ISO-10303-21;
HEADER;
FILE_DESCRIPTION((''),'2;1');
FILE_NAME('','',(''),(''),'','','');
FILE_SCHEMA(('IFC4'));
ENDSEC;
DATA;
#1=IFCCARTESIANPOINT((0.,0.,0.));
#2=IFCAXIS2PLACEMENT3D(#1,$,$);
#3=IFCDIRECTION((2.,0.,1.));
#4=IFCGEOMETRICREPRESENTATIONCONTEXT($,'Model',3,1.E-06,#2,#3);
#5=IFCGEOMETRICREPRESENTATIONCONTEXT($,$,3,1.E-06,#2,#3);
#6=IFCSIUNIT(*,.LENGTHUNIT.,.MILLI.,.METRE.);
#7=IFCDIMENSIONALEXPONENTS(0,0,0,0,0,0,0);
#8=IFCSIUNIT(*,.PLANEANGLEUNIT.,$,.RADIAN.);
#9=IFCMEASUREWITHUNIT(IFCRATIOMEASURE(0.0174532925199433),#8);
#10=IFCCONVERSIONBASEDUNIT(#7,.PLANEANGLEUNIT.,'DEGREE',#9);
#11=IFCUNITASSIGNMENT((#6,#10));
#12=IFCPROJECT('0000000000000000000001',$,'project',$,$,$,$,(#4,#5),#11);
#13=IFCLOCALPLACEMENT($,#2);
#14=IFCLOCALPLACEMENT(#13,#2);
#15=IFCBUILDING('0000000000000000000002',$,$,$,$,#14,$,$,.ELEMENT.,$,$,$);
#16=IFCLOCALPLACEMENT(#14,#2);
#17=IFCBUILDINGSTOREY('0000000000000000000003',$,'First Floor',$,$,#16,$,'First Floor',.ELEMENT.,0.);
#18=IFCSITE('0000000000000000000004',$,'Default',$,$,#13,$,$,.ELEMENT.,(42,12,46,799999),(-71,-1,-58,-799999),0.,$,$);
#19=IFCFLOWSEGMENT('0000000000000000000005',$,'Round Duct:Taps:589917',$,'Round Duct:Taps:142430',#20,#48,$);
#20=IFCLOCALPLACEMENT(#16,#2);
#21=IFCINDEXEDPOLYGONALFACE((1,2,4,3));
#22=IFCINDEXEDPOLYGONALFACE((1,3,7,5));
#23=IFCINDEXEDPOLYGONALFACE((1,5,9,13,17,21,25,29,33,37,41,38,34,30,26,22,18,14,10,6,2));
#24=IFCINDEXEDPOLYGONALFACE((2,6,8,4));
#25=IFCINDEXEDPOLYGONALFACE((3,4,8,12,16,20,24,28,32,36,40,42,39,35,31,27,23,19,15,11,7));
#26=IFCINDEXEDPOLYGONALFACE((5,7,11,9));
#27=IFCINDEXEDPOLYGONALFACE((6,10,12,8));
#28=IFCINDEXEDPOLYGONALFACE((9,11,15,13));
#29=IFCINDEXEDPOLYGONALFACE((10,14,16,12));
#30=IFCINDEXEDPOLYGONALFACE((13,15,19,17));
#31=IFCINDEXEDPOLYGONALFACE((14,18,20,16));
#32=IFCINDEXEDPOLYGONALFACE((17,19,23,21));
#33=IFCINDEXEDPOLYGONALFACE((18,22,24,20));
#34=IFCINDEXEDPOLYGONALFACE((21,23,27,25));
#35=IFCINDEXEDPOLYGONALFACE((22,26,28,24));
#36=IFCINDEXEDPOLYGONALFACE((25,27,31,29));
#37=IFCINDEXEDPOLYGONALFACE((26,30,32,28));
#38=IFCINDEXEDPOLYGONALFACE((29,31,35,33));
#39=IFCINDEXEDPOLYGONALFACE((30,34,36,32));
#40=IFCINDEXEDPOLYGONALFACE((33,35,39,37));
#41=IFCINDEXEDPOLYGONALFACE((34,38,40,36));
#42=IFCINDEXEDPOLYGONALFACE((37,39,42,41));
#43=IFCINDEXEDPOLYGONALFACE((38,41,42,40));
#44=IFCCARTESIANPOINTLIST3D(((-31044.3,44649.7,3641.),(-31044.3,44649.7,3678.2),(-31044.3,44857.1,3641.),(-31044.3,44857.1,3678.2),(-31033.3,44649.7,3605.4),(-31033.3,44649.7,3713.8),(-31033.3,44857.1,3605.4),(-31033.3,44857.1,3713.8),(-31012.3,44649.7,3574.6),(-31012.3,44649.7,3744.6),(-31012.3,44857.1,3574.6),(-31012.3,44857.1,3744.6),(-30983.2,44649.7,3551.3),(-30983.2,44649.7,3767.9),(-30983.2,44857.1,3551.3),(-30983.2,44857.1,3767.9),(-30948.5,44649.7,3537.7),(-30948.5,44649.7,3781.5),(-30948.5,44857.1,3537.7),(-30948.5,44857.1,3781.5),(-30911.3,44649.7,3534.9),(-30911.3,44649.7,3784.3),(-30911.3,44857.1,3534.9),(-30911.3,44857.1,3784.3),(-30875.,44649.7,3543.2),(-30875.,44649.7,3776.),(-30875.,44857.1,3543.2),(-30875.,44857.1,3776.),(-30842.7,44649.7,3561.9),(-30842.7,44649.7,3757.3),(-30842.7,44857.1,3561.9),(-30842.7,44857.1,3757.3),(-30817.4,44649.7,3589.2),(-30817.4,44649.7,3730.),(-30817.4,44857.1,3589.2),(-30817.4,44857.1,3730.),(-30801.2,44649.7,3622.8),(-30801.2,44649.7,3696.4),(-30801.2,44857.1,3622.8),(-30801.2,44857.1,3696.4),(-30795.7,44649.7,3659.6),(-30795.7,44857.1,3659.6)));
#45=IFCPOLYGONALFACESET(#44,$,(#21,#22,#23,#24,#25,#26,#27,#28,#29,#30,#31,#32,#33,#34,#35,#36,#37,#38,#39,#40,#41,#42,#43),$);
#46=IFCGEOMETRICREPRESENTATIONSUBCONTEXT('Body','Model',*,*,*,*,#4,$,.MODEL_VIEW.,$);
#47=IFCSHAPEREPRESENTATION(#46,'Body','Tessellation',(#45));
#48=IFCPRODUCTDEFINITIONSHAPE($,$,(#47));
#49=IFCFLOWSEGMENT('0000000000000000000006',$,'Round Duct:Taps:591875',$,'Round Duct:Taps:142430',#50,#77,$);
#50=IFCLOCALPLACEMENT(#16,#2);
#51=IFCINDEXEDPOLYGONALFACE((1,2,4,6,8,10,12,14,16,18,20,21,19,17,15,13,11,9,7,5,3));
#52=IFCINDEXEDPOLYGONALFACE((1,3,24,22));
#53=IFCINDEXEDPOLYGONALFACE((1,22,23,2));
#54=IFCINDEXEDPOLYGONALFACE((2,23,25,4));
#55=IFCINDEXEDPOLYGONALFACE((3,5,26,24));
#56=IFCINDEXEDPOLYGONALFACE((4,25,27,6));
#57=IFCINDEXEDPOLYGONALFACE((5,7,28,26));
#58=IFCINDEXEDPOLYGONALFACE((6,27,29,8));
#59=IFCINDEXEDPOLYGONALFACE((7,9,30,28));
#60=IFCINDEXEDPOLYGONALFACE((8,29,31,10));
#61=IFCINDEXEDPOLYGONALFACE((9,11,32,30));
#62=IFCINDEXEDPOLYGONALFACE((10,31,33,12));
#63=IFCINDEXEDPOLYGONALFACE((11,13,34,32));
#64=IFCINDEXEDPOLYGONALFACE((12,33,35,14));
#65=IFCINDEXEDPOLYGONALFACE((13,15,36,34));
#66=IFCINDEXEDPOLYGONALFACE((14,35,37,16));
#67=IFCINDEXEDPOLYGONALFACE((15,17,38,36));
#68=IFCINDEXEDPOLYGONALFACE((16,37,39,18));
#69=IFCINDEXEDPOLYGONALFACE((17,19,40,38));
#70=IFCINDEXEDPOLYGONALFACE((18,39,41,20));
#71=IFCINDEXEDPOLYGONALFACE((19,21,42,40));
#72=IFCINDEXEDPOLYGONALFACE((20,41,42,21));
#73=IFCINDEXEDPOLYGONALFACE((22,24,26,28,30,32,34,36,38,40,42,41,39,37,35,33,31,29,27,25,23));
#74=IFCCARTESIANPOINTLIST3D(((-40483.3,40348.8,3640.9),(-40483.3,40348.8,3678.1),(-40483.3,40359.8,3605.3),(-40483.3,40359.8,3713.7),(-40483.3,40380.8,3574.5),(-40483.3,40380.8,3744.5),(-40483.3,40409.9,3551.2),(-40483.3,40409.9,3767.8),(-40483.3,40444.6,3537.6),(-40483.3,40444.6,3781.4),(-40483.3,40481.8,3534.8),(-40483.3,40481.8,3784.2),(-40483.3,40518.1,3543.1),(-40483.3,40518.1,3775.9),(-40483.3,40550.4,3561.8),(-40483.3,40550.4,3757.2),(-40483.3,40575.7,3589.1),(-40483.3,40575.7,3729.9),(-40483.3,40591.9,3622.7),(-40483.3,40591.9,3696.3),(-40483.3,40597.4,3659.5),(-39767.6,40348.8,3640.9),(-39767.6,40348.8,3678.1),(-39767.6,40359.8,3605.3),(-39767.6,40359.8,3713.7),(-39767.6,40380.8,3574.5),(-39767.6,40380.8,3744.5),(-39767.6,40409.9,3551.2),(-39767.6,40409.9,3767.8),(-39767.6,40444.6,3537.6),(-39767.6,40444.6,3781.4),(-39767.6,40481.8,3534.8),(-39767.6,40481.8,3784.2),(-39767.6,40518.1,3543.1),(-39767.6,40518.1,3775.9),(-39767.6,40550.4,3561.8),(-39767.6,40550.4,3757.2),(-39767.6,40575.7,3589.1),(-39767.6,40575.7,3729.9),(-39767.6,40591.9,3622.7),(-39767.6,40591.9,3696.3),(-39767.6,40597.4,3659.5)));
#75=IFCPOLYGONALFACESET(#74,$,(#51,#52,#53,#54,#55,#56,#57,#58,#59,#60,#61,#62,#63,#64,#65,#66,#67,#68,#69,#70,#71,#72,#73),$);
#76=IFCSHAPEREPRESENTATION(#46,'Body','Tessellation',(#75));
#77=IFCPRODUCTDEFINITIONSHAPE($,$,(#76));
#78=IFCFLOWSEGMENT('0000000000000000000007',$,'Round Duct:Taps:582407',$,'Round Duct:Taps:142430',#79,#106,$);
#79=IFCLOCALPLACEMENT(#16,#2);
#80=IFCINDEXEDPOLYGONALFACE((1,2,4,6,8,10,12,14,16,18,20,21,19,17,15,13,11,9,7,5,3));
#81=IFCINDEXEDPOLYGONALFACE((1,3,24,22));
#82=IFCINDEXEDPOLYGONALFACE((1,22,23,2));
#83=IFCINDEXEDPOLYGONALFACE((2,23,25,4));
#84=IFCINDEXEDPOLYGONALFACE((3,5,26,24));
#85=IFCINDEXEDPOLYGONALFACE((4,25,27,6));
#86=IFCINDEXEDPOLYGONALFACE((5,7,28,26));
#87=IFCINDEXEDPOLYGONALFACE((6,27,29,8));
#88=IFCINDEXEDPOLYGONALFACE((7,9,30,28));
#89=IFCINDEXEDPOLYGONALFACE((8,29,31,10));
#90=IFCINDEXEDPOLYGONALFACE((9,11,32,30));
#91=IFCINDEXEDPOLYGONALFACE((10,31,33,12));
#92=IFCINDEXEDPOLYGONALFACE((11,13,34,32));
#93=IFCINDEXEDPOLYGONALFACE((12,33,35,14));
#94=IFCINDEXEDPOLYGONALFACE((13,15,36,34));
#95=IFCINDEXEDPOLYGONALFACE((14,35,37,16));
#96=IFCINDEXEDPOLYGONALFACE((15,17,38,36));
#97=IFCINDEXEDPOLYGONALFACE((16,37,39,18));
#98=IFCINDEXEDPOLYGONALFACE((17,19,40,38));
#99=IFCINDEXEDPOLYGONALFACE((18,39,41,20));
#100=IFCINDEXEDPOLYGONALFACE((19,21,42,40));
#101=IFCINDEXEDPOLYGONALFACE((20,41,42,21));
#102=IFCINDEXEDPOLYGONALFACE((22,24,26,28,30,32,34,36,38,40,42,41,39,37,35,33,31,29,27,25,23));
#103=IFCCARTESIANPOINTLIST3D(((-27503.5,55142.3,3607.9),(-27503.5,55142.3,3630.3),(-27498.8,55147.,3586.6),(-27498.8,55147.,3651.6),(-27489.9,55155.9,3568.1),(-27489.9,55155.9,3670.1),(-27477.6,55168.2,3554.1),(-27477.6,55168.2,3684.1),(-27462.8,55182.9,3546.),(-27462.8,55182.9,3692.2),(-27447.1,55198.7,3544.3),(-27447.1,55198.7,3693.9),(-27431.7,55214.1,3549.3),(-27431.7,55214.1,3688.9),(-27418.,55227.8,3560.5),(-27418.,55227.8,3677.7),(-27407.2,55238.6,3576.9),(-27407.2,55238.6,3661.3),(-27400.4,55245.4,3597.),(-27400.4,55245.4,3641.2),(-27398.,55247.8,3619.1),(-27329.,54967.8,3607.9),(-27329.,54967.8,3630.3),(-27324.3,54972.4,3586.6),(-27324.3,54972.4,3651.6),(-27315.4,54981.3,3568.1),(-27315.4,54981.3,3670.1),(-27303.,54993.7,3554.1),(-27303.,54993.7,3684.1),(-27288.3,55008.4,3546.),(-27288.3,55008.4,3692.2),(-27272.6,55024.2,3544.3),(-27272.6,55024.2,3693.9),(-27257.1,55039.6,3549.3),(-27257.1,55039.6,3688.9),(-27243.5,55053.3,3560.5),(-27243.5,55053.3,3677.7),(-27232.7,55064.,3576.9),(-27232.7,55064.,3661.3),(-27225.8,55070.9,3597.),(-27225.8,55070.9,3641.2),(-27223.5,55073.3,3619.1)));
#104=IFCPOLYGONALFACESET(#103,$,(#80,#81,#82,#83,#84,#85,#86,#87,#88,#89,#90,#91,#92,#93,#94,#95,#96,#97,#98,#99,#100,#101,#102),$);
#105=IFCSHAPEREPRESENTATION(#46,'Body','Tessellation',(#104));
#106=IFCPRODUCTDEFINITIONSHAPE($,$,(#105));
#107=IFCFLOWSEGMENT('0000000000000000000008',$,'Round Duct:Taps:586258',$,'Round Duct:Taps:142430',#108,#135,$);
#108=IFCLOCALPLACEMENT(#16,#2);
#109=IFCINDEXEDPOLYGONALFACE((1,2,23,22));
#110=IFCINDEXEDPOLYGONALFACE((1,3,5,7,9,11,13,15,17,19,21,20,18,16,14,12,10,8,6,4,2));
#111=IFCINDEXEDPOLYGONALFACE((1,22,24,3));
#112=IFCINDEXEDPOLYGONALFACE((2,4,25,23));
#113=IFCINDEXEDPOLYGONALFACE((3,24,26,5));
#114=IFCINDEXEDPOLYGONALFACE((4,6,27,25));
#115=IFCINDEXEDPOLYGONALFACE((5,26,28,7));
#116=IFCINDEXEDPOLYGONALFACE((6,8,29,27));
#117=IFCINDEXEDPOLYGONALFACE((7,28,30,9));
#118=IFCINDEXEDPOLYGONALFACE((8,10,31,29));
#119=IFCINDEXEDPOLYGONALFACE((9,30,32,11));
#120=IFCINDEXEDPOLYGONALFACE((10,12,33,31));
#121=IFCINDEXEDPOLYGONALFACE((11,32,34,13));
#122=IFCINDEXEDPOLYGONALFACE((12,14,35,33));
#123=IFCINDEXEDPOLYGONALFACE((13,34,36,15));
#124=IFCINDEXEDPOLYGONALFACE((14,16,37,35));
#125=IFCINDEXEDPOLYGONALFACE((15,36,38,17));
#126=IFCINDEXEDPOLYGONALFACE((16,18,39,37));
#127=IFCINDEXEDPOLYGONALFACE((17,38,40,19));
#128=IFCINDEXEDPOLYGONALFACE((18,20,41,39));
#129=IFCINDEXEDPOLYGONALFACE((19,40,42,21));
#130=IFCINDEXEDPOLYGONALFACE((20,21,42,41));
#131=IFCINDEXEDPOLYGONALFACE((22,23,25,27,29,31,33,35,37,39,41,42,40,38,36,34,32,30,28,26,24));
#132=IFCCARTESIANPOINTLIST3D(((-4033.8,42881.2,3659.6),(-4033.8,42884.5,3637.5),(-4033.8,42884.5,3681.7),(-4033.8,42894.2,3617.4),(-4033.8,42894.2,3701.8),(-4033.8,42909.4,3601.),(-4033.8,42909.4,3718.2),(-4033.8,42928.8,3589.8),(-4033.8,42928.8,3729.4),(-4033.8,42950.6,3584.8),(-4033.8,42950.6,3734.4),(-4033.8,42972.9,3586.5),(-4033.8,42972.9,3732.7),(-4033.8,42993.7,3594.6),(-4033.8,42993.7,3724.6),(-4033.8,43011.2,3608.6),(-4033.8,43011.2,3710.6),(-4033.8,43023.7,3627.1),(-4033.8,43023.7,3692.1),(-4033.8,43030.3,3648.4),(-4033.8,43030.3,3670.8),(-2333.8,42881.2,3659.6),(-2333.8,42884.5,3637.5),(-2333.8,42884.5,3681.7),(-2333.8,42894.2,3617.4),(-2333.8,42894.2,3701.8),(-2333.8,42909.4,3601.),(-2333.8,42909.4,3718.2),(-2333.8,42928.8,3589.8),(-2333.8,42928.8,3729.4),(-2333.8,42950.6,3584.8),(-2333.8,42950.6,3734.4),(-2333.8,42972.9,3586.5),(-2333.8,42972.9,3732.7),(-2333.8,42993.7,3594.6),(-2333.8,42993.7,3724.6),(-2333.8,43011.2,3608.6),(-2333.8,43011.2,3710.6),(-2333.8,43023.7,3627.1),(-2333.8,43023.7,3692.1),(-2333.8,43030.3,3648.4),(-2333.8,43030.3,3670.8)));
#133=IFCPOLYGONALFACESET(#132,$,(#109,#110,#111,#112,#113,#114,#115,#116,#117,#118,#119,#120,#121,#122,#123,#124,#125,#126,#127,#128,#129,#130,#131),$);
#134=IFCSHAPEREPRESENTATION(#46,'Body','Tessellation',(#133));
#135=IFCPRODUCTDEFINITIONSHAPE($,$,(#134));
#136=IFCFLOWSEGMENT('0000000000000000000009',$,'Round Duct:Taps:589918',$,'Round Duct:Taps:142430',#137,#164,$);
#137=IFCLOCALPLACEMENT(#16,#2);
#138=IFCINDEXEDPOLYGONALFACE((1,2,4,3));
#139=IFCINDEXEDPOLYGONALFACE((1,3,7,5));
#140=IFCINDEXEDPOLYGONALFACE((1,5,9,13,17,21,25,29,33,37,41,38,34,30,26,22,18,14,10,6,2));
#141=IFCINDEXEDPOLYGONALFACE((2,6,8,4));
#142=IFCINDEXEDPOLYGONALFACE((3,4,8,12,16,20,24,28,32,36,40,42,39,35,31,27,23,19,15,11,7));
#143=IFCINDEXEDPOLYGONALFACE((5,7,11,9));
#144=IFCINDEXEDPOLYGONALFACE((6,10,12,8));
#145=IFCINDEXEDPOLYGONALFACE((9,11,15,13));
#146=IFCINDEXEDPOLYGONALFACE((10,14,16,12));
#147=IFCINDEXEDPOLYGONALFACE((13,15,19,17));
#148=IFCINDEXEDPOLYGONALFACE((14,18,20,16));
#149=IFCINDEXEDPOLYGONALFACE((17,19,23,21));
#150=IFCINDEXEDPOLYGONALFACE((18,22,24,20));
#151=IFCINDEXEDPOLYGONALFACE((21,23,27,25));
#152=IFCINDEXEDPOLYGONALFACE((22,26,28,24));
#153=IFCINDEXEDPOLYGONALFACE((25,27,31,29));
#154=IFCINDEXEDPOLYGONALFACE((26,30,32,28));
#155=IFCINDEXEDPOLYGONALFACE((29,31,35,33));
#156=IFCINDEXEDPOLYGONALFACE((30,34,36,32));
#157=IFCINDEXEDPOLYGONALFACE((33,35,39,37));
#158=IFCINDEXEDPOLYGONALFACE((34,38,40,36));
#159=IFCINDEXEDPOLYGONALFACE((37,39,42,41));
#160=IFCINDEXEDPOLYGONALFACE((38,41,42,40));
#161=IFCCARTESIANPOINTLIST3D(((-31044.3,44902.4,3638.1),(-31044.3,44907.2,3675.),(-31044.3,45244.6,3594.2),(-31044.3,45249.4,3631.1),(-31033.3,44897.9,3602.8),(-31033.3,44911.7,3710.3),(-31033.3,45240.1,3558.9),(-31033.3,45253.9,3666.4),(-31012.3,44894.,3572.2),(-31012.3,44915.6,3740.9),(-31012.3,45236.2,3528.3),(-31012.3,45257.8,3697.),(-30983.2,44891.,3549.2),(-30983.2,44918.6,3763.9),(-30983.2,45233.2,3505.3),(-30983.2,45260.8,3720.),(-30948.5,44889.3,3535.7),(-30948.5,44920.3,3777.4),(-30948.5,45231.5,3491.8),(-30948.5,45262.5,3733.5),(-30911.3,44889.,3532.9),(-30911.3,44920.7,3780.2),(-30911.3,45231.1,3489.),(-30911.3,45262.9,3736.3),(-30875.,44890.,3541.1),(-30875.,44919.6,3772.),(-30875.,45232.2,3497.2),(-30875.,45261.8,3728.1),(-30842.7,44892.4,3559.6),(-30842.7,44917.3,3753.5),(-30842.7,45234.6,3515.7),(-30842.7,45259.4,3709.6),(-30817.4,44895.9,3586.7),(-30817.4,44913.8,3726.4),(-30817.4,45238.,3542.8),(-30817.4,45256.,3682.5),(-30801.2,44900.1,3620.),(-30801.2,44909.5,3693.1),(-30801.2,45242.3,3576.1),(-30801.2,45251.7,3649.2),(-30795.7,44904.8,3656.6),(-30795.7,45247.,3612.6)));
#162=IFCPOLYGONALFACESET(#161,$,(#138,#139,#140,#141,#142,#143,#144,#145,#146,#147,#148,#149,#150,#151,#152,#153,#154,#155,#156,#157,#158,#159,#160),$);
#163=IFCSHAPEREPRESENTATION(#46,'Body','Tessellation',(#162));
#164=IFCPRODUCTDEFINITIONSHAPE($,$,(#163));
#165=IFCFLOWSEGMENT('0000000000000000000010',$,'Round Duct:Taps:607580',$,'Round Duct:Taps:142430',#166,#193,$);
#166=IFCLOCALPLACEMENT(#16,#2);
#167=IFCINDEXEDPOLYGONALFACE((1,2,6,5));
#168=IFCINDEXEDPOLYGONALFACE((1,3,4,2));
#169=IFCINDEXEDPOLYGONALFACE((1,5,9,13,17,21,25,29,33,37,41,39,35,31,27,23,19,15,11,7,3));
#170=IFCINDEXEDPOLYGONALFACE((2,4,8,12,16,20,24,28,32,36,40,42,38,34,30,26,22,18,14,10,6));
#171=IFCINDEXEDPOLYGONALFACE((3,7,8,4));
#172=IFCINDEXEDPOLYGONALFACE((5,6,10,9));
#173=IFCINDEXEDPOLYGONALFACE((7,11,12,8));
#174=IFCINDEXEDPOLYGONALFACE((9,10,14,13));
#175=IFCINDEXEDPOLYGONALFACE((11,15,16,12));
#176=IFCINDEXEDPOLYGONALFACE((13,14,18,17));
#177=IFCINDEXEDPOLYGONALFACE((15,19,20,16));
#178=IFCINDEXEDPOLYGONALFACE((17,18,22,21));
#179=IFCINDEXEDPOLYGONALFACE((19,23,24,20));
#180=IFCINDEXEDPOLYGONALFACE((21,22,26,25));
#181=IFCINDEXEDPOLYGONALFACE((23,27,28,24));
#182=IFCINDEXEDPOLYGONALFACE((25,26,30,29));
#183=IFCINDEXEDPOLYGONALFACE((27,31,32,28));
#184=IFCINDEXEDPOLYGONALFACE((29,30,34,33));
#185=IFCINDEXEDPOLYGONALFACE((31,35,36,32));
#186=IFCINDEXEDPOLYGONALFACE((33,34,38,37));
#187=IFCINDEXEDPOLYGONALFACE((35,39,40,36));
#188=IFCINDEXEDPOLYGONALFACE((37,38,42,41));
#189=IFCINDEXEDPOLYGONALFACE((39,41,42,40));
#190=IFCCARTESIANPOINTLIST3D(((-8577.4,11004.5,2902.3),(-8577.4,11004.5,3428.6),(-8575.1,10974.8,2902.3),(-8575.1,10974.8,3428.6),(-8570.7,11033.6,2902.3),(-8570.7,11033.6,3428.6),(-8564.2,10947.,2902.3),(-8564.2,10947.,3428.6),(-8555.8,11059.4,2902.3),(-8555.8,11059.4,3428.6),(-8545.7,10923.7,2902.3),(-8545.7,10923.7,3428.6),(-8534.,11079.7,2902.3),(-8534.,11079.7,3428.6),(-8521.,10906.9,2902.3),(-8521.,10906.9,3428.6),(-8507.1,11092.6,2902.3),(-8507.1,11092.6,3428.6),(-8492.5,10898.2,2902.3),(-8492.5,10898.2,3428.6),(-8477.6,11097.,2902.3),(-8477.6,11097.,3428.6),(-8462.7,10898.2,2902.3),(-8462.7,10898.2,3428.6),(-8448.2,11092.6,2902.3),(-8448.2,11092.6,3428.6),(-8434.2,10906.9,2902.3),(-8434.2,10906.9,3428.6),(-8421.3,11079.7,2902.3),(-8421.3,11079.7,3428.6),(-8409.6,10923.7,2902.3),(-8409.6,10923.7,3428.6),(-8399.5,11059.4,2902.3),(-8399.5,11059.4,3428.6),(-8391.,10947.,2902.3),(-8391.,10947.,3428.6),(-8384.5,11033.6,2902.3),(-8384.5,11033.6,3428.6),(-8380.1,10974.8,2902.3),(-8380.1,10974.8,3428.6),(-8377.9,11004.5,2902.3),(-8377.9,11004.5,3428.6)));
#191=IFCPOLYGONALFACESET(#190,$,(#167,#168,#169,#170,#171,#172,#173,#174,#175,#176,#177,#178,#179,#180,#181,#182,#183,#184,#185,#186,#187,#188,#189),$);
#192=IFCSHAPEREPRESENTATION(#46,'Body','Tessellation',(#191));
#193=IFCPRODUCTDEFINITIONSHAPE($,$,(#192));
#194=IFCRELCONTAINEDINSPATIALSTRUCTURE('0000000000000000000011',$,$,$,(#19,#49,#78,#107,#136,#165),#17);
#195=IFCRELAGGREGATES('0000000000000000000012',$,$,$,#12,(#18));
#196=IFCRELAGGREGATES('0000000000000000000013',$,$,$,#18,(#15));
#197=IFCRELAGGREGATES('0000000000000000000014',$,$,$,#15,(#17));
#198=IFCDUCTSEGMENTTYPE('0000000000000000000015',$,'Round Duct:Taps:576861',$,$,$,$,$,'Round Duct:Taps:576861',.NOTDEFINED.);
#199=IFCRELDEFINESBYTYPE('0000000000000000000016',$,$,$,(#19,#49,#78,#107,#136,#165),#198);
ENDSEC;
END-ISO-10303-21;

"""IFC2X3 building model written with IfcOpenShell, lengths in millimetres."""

from ifc_helpers import new_model, entity, si_unit, converted_unit, direction, frame, frame_2d, origin, origin_2d_with_axis, place, context, subcontext, project, spatial, circle, extrude, type_object, element, save


model = new_model("IFC2X3")

# Units and contexts
model_context = context("Model", 3, precision=1e-06, world=origin(), true_north=direction((2.0, 0.0, 1.0)))
context_of_model = context(None, 3, precision=1e-06, world=origin(), true_north=direction((2.0, 0.0, 1.0)))
body_context = subcontext(model_context, "Body", "Model", "MODEL_VIEW")
ifc_project = project(units=[si_unit("LENGTHUNIT", "METRE", prefix="MILLI"), converted_unit("PLANEANGLEUNIT", "DEGREE", entity("IfcRatioMeasure", 0.0174532925199433), si_unit("PLANEANGLEUNIT", "RADIAN"), dimensions=[0, 0, 0, 0, 0, 0, 0])], contexts=[model_context, context_of_model])

# Site, building, storey
site_placement = place(None, origin())
site = spatial("IfcSite", under=ifc_project, at=site_placement, Name="Default", CompositionType="ELEMENT", RefLatitude=(42, 12, 46, 799999), RefLongitude=(-71, -1, -58, -799999), RefElevation=0.0)
building_placement = place(site_placement, origin())
building = spatial("IfcBuilding", under=site, at=building_placement, CompositionType="ELEMENT")
storey_placement = place(building_placement, origin())
storey = spatial("IfcBuildingStorey", under=building, at=storey_placement, Name="First Floor", LongName="First Floor", CompositionType="ELEMENT", Elevation=0.0)

# Flow segments
duct_segment_type_1 = type_object("IfcDuctSegmentType", Name="Round Duct:Taps:576861", ElementType="Round Duct:Taps:576861", PredefinedType="NOTDEFINED")
flow_segment_1_placement = place(storey_placement, origin())
element("IfcFlowSegment", 1, at=flow_segment_1_placement, inside=storey, type_object=duct_segment_type_1, Name="Round Duct:Taps:589917", ObjectType="Round Duct:Taps:142430", context=body_context, shape_type="SweptSolid", body=[
    extrude(circle(Radius=125.0, at=origin_2d_with_axis()), frame((-30920.7, 44649.7, 3659.6), z_axis=(0.0, 1.0, 0.0), x_axis=(1.0, 0.0, 0.0)), (0.0, 0.0, 1.0), 207.4),
])
flow_segment_2_placement = place(storey_placement, origin())
element("IfcFlowSegment", 2, at=flow_segment_2_placement, inside=storey, type_object=duct_segment_type_1, Name="Round Duct:Taps:591875", ObjectType="Round Duct:Taps:142430", context=body_context, shape_type="SweptSolid", body=[
    extrude(circle(Radius=125.0, at=frame_2d((0.0, 0.0), x_axis=(1.0, 0.0))), frame((-40483.3, 40472.4, 3659.5), z_axis=(1.0, 0.0, 0.0), x_axis=(0.0, 1.0, 0.0)), (0.0, 0.0, 1.0), 715.7),
])
flow_segment_3_placement = place(storey_placement, origin())
element("IfcFlowSegment", 3, at=flow_segment_3_placement, inside=storey, type_object=duct_segment_type_1, Name="Round Duct:Taps:582407", ObjectType="Round Duct:Taps:142430", context=body_context, shape_type="SweptSolid", body=[
    extrude(circle(Radius=75.0, at=frame_2d((0.0, 0.0), x_axis=(1.0, 0.0))), frame((-27451.0, 55194.7, 3619.1), z_axis=(0.707107, -0.707107, 0.0), x_axis=(0.707107, 0.707107, 0.0)), (0.0, 0.0, 1.0), 246.8),
])
flow_segment_4_placement = place(storey_placement, origin())
element("IfcFlowSegment", 4, at=flow_segment_4_placement, inside=storey, type_object=duct_segment_type_1, Name="Round Duct:Taps:586258", ObjectType="Round Duct:Taps:142430", context=body_context, shape_type="SweptSolid", body=[
    extrude(circle(Radius=75.0, at=origin_2d_with_axis()), frame((-4033.8, 42956.2, 3659.6), z_axis=(1.0, 0.0, 0.0), x_axis=(0.0, -1.0, 0.0)), (0.0, 0.0, 1.0), 1700.0),
])
flow_segment_5_placement = place(storey_placement, origin())
element("IfcFlowSegment", 5, at=flow_segment_5_placement, inside=storey, type_object=duct_segment_type_1, Name="Round Duct:Taps:589918", ObjectType="Round Duct:Taps:142430", context=body_context, shape_type="SweptSolid", body=[
    extrude(circle(Radius=125.0, at=frame_2d((0.0, 0.0), x_axis=(1.0, 0.0))), frame((-30920.7, 45247.0, 3612.6), z_axis=(0.0, -0.99187, 0.127257), x_axis=(1.0, 0.0, 0.0)), (0.0, 0.0, 1.0), 345.0),
])
flow_segment_6_placement = place(storey_placement, origin())
element("IfcFlowSegment", 6, at=flow_segment_6_placement, inside=storey, type_object=duct_segment_type_1, Name="Round Duct:Taps:607580", ObjectType="Round Duct:Taps:142430", context=body_context, shape_type="SweptSolid", body=[
    extrude(circle(Radius=100.0, at=frame_2d((0.0, 0.0), x_axis=(1.0, 0.0))), frame((-8477.6, 10997.0, 2902.3), z_axis=(0.0, 0.0, 1.0), x_axis=(0.0, 1.0, 0.0)), (0.0, 0.0, 1.0), 526.3),
])

save(model, "model.ifc")
